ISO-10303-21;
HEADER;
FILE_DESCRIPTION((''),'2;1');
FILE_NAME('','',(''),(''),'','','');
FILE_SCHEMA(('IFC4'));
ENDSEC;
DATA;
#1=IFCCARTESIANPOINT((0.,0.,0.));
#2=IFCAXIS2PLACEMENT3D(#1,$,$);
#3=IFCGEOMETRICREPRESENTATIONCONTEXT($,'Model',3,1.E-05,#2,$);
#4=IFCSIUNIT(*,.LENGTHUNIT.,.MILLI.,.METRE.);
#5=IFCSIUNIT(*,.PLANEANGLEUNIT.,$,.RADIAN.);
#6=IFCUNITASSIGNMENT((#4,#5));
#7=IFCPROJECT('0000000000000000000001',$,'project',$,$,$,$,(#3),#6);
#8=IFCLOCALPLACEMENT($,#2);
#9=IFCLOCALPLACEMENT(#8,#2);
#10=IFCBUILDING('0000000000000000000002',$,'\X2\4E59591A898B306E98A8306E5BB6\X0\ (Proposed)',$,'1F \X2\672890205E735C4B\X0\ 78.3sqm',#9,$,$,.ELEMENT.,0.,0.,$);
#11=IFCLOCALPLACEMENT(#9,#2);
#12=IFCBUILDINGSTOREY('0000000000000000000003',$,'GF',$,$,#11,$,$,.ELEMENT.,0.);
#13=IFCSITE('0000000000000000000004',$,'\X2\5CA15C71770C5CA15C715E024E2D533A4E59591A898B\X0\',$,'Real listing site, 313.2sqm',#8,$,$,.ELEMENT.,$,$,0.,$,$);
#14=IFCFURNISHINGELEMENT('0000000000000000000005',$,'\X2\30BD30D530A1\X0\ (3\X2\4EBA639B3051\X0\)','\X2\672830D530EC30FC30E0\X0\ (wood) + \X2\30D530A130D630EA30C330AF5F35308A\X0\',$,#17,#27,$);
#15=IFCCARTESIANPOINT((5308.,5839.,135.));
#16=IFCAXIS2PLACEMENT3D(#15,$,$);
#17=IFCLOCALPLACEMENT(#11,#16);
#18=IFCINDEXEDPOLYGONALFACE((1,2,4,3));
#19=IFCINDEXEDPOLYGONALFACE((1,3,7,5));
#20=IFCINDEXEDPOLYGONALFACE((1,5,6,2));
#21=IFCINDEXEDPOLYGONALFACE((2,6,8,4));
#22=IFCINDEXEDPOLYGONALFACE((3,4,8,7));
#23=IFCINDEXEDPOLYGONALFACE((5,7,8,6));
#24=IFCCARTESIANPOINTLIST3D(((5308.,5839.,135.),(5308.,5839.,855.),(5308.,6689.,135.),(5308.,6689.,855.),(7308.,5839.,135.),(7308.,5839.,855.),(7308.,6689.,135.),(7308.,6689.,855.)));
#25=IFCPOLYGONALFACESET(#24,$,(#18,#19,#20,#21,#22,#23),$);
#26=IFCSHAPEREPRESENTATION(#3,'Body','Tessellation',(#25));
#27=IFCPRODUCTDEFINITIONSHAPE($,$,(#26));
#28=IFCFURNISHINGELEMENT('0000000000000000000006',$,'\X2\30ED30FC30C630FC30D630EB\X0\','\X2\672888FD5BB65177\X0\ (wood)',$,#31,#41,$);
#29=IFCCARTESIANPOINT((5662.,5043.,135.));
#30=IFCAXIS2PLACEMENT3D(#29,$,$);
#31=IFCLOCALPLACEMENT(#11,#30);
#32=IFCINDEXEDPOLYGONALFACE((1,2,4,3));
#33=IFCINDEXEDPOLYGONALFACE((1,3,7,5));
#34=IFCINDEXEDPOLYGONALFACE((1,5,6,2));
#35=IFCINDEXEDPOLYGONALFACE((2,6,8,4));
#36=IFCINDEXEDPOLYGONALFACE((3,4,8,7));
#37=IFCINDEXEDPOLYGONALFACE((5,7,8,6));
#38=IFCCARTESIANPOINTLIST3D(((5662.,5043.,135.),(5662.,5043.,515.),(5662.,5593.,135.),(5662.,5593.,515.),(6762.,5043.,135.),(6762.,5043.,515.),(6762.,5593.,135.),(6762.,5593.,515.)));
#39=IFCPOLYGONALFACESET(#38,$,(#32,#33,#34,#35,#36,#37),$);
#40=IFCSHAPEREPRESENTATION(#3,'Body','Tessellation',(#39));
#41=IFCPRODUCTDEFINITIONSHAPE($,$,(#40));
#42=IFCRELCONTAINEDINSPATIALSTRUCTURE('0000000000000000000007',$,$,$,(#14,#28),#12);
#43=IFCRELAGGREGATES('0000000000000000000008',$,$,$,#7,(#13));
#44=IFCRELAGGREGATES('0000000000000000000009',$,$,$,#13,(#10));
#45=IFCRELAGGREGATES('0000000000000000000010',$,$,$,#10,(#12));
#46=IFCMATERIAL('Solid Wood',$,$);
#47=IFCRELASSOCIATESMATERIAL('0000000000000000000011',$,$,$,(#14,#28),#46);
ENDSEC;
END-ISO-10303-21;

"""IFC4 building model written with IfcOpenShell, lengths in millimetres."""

from ifc_helpers import new_model, si_unit, frame, frame_2d, origin, place, context, project, spatial, rectangle, extrude, material, element, save


model = new_model("IFC4")

# Units and contexts
model_context = context("Model", 3, precision=1e-05, world=origin())
ifc_project = project(units=[si_unit("LENGTHUNIT", "METRE", prefix="MILLI"), si_unit("PLANEANGLEUNIT", "RADIAN")], contexts=[model_context])

# Site, building, storey
site_placement = place(None, origin())
site = spatial("IfcSite", under=ifc_project, at=site_placement, Name="岡山県岡山市中区乙多見", ObjectType="Real listing site, 313.2sqm", CompositionType="ELEMENT", RefElevation=0.0)
building_placement = place(site_placement, origin())
building = spatial("IfcBuilding", under=site, at=building_placement, Name="乙多見の風の家 (Proposed)", ObjectType="1F 木造平屋 78.3sqm", CompositionType="ELEMENT", ElevationOfRefHeight=0.0, ElevationOfTerrain=0.0)
storey_placement = place(building_placement, origin())
storey = spatial("IfcBuildingStorey", under=building, at=storey_placement, Name="GF", CompositionType="ELEMENT", Elevation=0.0)

# Shared definitions
ifc_material_1 = material(Name="Solid Wood")

# Furnishing elements
furnishing_1_placement = place(storey_placement, frame((5308.0, 5839.0, 135.0)))
element("IfcFurnishingElement", 1, at=furnishing_1_placement, inside=storey, material=ifc_material_1, Name="ソファ (3人掛け)", Description="木フレーム (wood) + ファブリック張り", context=model_context, shape_type="SweptSolid", body=[
    extrude(rectangle(XDim=2000.0, YDim=850.0, at=frame_2d((1000.0, 425.0))), frame((5308.0, 5839.0, 135.0)), (0.0, 0.0, 1.0), 720.0),
])
furnishing_2_placement = place(storey_placement, frame((5662.0, 5043.0, 135.0)))
element("IfcFurnishingElement", 2, at=furnishing_2_placement, inside=storey, material=ifc_material_1, Name="ローテーブル", Description="木製家具 (wood)", context=model_context, shape_type="SweptSolid", body=[
    extrude(rectangle(XDim=1100.0, YDim=550.0, at=frame_2d((550.0, 275.0))), frame((5662.0, 5043.0, 135.0)), (0.0, 0.0, 1.0), 380.0),
])

save(model, "model.ifc")
